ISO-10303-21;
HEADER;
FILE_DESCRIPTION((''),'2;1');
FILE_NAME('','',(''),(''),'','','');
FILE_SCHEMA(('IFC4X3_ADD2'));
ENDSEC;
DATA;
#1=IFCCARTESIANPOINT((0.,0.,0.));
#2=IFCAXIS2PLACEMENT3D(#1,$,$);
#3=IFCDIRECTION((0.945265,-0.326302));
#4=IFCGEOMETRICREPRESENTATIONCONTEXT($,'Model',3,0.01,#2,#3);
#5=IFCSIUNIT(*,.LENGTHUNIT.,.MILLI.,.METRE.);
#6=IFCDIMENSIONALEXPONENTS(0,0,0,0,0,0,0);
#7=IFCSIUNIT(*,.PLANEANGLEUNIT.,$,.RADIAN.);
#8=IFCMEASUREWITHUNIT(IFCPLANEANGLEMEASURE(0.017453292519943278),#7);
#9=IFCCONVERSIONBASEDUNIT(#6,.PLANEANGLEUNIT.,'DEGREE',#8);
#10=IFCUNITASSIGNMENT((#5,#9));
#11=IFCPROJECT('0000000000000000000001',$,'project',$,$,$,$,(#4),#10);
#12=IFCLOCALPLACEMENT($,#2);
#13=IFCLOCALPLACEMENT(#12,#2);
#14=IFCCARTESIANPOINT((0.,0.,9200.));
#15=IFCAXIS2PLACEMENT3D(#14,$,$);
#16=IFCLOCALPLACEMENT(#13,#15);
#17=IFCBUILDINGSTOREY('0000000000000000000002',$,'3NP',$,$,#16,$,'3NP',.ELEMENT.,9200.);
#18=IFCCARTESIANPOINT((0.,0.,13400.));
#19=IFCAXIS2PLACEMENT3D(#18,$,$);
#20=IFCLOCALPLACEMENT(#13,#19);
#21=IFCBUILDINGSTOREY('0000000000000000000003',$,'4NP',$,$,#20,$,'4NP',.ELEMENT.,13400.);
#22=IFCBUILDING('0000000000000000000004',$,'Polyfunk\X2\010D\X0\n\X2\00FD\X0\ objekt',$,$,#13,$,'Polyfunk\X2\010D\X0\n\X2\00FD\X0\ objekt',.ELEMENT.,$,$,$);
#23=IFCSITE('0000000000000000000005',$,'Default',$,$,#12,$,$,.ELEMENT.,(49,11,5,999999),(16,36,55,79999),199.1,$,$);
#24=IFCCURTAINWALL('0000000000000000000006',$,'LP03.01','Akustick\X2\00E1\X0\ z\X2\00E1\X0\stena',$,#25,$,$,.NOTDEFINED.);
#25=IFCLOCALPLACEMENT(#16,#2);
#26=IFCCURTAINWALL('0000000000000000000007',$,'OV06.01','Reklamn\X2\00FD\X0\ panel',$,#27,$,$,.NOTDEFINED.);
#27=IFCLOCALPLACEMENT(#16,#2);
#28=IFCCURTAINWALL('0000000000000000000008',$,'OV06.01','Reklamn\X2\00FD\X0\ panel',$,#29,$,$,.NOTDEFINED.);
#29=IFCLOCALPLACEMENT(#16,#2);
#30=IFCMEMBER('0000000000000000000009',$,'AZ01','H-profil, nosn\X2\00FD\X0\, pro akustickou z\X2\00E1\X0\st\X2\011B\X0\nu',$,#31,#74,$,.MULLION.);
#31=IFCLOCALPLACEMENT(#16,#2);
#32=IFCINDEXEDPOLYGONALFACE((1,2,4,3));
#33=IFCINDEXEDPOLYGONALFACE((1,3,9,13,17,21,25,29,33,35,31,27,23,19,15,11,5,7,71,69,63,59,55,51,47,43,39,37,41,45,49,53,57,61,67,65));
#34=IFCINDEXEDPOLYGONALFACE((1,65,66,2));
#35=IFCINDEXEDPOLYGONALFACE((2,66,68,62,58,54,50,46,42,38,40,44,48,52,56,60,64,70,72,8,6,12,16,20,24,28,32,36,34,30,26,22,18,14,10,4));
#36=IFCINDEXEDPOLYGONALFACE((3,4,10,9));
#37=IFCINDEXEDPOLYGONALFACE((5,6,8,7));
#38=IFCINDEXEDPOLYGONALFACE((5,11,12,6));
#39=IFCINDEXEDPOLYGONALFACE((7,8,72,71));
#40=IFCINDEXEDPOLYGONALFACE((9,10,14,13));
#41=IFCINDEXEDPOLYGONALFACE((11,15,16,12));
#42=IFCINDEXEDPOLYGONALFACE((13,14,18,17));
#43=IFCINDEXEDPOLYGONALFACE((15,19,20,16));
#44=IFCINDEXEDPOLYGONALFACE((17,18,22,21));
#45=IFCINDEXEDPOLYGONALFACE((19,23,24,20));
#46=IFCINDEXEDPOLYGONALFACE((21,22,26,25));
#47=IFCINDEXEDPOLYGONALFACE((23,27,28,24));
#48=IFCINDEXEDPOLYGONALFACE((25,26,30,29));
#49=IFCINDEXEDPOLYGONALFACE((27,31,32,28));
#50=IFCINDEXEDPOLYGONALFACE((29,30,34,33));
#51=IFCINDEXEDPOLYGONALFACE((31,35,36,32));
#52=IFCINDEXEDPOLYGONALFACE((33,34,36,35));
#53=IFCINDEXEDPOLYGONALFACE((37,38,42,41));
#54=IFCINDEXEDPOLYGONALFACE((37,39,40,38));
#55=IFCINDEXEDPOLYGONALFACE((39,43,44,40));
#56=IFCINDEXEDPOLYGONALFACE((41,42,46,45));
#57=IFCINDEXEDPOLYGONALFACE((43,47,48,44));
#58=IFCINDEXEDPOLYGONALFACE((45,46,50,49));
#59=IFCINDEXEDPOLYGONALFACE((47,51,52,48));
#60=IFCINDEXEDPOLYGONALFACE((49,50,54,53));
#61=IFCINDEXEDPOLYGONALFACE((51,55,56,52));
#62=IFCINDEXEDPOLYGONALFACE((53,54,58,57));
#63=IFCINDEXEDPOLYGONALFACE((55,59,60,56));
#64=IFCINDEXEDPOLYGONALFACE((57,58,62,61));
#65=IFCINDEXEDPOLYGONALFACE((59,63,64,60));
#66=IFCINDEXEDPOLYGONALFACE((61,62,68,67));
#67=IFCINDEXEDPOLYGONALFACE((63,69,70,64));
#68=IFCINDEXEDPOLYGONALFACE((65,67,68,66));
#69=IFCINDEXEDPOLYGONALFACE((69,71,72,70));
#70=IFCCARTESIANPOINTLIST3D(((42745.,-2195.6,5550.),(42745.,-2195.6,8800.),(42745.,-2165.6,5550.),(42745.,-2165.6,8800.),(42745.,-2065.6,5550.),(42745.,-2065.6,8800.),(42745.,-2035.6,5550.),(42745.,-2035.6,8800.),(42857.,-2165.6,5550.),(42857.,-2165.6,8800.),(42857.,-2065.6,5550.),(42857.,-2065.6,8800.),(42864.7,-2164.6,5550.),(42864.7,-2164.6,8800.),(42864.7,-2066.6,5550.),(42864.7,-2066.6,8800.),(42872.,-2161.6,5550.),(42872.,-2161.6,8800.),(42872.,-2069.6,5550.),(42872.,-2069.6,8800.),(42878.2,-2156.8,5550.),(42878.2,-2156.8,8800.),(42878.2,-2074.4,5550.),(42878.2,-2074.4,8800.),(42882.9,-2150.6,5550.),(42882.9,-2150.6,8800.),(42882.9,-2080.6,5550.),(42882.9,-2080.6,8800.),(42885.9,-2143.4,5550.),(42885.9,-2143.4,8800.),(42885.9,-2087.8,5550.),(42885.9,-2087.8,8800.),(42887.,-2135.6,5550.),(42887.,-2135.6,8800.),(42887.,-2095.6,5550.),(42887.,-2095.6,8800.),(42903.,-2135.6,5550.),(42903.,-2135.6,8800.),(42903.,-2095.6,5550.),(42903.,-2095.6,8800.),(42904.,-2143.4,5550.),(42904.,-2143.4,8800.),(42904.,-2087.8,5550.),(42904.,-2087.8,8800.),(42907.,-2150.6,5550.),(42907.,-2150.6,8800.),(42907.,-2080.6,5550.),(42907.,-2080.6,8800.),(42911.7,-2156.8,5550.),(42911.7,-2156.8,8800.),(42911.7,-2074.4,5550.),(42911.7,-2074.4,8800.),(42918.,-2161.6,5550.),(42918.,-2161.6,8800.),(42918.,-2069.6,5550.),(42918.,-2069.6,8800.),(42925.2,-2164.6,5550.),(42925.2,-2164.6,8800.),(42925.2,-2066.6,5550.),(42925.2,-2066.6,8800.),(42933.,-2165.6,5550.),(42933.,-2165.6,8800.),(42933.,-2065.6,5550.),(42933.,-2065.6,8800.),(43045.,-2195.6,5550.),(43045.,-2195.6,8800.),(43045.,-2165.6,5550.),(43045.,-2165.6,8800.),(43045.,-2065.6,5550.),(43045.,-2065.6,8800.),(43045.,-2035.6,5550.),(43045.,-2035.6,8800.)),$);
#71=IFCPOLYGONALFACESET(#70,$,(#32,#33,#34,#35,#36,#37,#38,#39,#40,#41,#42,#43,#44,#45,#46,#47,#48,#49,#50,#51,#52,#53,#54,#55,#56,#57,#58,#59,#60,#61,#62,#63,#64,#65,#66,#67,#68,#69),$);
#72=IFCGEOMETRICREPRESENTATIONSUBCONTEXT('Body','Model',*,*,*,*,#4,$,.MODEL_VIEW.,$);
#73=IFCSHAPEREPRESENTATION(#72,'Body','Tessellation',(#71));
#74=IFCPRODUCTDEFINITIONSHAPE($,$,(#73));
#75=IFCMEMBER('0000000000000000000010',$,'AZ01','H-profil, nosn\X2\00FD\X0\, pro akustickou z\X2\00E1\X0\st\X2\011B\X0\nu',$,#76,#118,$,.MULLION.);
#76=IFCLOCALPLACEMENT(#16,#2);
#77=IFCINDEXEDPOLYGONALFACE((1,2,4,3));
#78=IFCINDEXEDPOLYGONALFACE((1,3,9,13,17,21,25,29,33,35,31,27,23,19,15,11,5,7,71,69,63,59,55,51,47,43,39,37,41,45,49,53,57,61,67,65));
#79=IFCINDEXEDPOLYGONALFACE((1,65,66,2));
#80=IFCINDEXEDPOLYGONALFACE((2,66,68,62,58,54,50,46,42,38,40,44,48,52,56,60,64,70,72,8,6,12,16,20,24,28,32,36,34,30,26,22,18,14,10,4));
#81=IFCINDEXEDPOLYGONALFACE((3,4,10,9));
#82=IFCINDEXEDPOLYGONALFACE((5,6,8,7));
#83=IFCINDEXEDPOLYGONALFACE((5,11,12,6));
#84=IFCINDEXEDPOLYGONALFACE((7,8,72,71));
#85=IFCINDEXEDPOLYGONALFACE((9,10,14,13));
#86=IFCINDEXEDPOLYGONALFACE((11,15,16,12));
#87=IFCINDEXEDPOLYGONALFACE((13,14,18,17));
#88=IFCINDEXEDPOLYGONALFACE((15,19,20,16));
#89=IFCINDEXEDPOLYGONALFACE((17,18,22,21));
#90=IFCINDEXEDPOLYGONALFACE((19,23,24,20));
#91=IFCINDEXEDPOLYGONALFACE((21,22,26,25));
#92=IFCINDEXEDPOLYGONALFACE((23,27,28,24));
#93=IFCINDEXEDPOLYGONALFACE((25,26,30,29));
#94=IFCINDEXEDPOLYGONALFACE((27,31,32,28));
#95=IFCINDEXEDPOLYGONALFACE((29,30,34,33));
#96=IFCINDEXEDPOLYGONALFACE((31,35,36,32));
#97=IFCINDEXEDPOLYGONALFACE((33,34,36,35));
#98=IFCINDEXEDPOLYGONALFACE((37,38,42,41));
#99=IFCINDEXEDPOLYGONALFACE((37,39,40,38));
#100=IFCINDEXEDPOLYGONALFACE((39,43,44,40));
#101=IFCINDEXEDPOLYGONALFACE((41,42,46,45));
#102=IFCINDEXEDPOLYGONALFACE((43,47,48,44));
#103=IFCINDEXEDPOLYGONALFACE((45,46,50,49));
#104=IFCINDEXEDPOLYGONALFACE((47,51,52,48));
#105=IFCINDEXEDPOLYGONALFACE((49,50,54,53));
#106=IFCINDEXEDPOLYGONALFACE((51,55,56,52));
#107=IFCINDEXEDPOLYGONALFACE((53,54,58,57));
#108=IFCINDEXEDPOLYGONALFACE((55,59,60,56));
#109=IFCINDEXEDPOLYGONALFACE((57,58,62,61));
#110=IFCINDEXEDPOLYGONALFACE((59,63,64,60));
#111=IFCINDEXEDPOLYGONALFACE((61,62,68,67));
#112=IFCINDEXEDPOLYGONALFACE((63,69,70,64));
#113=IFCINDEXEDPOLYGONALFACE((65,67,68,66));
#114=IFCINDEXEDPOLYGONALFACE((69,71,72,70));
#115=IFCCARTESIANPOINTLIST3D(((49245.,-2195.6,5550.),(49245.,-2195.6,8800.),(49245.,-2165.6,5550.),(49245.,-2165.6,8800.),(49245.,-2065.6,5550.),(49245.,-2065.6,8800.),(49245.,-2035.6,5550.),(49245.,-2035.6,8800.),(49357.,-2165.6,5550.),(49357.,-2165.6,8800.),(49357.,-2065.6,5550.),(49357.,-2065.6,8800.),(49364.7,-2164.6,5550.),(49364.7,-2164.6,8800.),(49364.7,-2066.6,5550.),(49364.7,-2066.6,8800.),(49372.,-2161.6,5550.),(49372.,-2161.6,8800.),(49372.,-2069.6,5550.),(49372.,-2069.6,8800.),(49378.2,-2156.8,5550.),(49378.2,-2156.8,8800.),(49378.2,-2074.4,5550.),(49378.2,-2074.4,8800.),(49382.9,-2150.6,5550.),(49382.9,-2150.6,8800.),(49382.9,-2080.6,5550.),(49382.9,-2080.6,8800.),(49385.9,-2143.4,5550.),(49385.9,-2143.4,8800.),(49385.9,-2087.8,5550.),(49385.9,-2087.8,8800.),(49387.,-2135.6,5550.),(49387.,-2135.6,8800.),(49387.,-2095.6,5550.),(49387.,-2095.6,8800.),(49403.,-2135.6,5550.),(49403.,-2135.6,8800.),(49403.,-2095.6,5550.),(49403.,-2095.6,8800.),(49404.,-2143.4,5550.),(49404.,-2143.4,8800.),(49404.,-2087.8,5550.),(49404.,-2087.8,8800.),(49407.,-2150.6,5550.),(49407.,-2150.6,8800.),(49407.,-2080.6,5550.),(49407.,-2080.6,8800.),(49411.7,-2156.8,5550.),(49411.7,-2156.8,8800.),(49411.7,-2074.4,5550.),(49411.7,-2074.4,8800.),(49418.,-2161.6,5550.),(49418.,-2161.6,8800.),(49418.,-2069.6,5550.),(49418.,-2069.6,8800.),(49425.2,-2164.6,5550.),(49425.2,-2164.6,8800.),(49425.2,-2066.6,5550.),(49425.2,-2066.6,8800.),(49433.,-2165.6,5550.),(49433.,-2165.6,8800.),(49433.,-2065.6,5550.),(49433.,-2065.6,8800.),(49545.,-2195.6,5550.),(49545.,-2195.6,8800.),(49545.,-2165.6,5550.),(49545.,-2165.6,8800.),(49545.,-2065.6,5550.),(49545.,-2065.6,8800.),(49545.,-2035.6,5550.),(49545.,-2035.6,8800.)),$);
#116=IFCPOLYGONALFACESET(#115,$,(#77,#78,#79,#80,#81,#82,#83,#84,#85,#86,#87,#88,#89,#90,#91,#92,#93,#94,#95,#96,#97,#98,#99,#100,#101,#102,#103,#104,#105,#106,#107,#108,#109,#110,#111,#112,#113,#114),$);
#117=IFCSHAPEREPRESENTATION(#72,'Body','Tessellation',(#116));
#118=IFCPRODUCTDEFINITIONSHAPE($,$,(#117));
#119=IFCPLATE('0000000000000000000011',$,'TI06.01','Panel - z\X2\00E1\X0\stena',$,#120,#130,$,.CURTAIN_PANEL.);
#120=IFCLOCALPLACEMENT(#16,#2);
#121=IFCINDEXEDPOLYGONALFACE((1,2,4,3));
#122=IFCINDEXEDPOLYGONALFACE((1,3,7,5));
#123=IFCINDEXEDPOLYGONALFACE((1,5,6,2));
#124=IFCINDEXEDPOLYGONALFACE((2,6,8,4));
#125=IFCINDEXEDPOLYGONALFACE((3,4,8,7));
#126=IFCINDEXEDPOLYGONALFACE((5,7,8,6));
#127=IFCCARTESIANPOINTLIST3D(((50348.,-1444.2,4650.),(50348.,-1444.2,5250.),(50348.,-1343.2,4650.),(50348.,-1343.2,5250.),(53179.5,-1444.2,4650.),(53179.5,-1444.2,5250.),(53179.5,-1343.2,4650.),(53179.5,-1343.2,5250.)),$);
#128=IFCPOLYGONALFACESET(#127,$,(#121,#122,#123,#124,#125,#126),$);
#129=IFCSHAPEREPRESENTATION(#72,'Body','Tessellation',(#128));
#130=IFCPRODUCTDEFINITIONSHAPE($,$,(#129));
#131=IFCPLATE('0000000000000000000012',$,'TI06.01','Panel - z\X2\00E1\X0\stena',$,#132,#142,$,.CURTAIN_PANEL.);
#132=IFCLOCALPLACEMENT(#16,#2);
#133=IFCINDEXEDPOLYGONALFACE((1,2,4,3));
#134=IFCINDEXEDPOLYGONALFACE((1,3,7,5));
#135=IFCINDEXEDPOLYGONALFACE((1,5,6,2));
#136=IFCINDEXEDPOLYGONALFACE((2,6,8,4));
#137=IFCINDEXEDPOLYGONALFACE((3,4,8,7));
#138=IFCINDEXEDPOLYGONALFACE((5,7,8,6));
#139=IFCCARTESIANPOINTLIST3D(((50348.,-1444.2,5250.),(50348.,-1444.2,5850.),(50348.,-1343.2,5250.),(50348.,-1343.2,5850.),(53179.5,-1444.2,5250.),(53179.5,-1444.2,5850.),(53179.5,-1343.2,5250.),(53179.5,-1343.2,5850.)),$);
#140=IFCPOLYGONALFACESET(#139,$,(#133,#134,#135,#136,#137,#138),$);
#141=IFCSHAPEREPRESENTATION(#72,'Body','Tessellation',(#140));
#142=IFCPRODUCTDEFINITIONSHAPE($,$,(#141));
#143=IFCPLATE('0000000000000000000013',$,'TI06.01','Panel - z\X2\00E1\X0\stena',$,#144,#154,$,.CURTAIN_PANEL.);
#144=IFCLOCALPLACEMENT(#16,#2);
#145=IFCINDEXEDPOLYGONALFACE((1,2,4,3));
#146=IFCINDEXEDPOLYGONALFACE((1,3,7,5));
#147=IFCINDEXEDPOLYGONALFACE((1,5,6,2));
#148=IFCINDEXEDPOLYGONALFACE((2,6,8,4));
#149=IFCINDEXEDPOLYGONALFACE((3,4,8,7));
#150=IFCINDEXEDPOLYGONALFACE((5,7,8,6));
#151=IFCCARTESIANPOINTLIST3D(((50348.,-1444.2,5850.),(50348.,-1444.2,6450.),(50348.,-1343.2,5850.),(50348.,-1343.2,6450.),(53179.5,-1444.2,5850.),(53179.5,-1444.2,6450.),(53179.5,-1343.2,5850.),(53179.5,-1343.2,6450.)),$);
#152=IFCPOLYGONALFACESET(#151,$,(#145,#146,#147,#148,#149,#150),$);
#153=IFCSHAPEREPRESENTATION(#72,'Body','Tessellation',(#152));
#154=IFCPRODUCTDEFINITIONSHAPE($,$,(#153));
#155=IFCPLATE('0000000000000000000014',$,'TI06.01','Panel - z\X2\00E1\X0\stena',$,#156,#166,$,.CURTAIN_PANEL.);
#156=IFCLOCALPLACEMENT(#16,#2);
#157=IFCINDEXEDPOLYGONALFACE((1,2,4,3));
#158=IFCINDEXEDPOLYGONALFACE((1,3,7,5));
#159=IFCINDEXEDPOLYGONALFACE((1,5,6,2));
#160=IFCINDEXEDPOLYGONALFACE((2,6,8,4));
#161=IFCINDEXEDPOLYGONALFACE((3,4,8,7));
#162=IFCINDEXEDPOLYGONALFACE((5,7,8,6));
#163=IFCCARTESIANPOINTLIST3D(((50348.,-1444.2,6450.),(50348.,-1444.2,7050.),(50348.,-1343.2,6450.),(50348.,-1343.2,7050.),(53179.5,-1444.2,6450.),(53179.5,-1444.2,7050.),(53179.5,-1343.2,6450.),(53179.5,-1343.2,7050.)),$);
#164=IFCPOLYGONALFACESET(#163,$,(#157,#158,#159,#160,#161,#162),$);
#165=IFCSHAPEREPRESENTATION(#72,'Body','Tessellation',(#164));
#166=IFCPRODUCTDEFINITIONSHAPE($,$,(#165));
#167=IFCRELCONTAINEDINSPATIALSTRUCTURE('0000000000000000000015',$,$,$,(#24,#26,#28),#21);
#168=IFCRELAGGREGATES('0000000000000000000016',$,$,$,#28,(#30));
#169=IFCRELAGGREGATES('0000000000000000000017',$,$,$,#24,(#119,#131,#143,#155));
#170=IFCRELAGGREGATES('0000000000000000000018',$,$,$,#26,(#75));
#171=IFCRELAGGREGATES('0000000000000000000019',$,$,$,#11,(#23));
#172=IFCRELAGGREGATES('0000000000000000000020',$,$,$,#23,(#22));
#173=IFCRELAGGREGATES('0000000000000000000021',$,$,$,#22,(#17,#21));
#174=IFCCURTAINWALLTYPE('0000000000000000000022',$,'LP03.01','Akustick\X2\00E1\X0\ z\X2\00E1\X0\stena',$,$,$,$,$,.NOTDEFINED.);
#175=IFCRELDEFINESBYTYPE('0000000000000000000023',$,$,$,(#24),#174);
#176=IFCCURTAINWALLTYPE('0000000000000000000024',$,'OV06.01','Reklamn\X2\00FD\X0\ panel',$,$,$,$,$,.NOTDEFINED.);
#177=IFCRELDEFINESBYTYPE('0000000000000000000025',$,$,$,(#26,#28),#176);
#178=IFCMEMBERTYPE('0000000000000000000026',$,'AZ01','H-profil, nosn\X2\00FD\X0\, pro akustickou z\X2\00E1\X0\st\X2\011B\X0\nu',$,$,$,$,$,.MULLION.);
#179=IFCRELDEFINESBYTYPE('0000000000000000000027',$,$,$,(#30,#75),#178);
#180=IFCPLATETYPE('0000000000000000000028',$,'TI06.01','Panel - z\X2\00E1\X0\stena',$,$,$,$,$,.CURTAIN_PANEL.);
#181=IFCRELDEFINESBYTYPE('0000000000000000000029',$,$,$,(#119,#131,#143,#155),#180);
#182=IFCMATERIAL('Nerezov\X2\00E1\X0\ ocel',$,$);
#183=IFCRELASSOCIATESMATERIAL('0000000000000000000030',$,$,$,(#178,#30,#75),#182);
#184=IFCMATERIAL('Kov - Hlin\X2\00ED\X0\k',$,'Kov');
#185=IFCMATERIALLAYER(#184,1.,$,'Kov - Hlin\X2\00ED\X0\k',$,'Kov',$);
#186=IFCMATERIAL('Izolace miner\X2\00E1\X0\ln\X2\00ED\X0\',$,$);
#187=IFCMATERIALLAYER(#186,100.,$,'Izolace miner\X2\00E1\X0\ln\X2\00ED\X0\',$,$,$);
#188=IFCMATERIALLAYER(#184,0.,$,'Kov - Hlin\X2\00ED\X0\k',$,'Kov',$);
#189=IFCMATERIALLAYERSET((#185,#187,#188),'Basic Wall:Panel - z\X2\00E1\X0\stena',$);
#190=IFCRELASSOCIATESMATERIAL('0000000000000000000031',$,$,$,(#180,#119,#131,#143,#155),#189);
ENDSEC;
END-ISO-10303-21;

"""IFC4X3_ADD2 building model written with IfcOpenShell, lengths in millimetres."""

from ifc_helpers import new_model, entity, si_unit, converted_unit, direction, frame, frame_2d, origin, place, context, subcontext, project, spatial, polyline, circle_curve, parameter, trimmed, segment, composite_curve, rectangle, outline, extrude, source, transform, mapped, material, layer, layer_set, layer_usage, material_profile, profile_set, profile_usage, type_object, element, aggregate, save


model = new_model("IFC4X3_ADD2")

# Units and contexts
model_context = context("Model", 3, precision=0.01, world=origin(), true_north=direction((0.945265, -0.326302)))
body_context = subcontext(model_context, "Body", "Model", "MODEL_VIEW")
ifc_project = project(units=[si_unit("LENGTHUNIT", "METRE", prefix="MILLI"), converted_unit("PLANEANGLEUNIT", "DEGREE", entity("IfcPlaneAngleMeasure", 0.017453292519943278), si_unit("PLANEANGLEUNIT", "RADIAN"), dimensions=[0, 0, 0, 0, 0, 0, 0])], contexts=[model_context])

# Site, building, storey
site_placement = place(None, origin())
site = spatial("IfcSite", under=ifc_project, at=site_placement, Name="Default", CompositionType="ELEMENT", RefLatitude=(49, 11, 5, 999999), RefLongitude=(16, 36, 55, 79999), RefElevation=199.1)
building_placement = place(site_placement, origin())
building = spatial("IfcBuilding", under=site, at=building_placement, Name="Polyfunkčný objekt", LongName="Polyfunkčný objekt", CompositionType="ELEMENT")
storey_1_placement = place(building_placement, frame((0.0, 0.0, 9200.0)))
storey_1 = spatial("IfcBuildingStorey", under=building, at=storey_1_placement, Name="3NP", LongName="3NP", CompositionType="ELEMENT", Elevation=9200.0)

# Shared definitions
storey_2_placement = place(building_placement, frame((0.0, 0.0, 13400.0)))
storey_2 = spatial("IfcBuildingStorey", under=building, at=storey_2_placement, Name="4NP", LongName="4NP", CompositionType="ELEMENT", Elevation=13400.0)

# Curtain wall
curtain_wall_type_1 = type_object("IfcCurtainWallType", Name="LP03.01", Description="Akustická zástena", PredefinedType="NOTDEFINED")
curtain_wall_1_placement = place(storey_2_placement, frame((0.0, 0.0, -13400.0)))
curtain_wall_1 = element("IfcCurtainWall", 1, at=curtain_wall_1_placement, inside=storey_2, type_object=curtain_wall_type_1, Name="LP03.01", Description="Akustická zástena", PredefinedType="NOTDEFINED")
ifc_material_1 = material(Name="Nerezová ocel")
ifc_material_profile_1 = material_profile(ifc_material_1, outline(composite_curve([segment(polyline([(50.0, -150.0), (80.0, -150.0)]), True, "CONTINUOUS"), segment(polyline([(80.0, -150.0), (80.0, 150.0)]), True, "CONTINUOUS"), segment(polyline([(80.0, 150.0), (50.0, 150.0)]), True, "CONTINUOUS"), segment(polyline([(50.0, 150.0), (50.0, 38.0)]), True, "CONTINUOUS"), segment(trimmed(circle_curve(frame_2d((20.0, 38.0), x_axis=(0.0, 1.0)), 30.0), [parameter(180.0)], [parameter(270.0)], True, "PARAMETER"), False, "CONTINUOUS"), segment(polyline([(20.0, 8.0), (-20.0, 8.0)]), True, "CONTINUOUS"), segment(trimmed(circle_curve(frame_2d((-20.0, 38.0), x_axis=(0.0, 1.0)), 30.0), [parameter(90.0)], [parameter(180.0)], True, "PARAMETER"), False, "CONTINUOUS"), segment(polyline([(-50.0, 38.0), (-50.0, 150.0)]), True, "CONTINUOUS"), segment(polyline([(-50.0, 150.0), (-80.0, 150.0)]), True, "CONTINUOUS"), segment(polyline([(-80.0, 150.0), (-80.0, -150.0)]), True, "CONTINUOUS"), segment(polyline([(-80.0, -150.0), (-50.0, -150.0)]), True, "CONTINUOUS"), segment(polyline([(-50.0, -150.0), (-50.0, -38.0)]), True, "CONTINUOUS"), segment(trimmed(circle_curve(frame_2d((-20.0, -38.0), x_axis=(0.0, 1.0)), 30.0), [parameter(0.0)], [parameter(90.0)], True, "PARAMETER"), False, "CONTINUOUS"), segment(polyline([(-20.0, -8.0), (20.0, -8.0)]), True, "CONTINUOUS"), segment(trimmed(circle_curve(frame_2d((20.0, -38.0), x_axis=(0.0, 1.0)), 30.0), [parameter(270.0)], [parameter(0.0)], True, "PARAMETER"), False, "CONTINUOUS"), segment(polyline([(50.0, -38.0), (50.0, -150.0)]), True, "CONTINUOUS")], self_intersect=False)), Name="Profil zástena")
ifc_profile_set_1 = profile_set([ifc_material_profile_1], Name="Profil zástena")
ifc_profile_usage_1 = profile_usage(ifc_profile_set_1)
member_type_1 = type_object("IfcMemberType", Name="AZ01", Description="H-profil, nosný, pro akustickou zástěnu", PredefinedType="MULLION", material=ifc_profile_set_1)

# Curtain walls
curtain_wall_type_2 = type_object("IfcCurtainWallType", Name="OV06.01", Description="Reklamný panel", PredefinedType="NOTDEFINED")
curtain_wall_2_placement = place(storey_2_placement, frame((0.0, 0.0, -13400.0)))
curtain_wall_2 = element("IfcCurtainWall", 2, at=curtain_wall_2_placement, inside=storey_2, type_object=curtain_wall_type_2, Name="OV06.01", Description="Reklamný panel", PredefinedType="NOTDEFINED")
curtain_wall_3_placement = place(storey_2_placement, frame((0.0, 0.0, -13400.0)))
curtain_wall_3 = element("IfcCurtainWall", 3, at=curtain_wall_3_placement, inside=storey_2, type_object=curtain_wall_type_2, Name="OV06.01", Description="Reklamný panel", PredefinedType="NOTDEFINED")

# Members
shared_shape_1 = source(origin(), body_context, "Body", "SweptSolid", [
    extrude(outline(composite_curve([segment(polyline([(-150.0, -50.0), (-150.0, -80.0)]), True, "CONTINUOUS"), segment(polyline([(-150.0, -80.0), (150.0, -80.0)]), True, "CONTINUOUS"), segment(polyline([(150.0, -80.0), (150.0, -50.0)]), True, "CONTINUOUS"), segment(polyline([(150.0, -50.0), (38.0, -50.0)]), True, "CONTINUOUS"), segment(trimmed(circle_curve(frame_2d((38.0, -20.0), x_axis=(1.0, 0.0)), 30.0), [parameter(180.0)], [parameter(270.0)], True, "PARAMETER"), False, "CONTINUOUS"), segment(polyline([(8.0, -20.0), (8.0, 20.0)]), True, "CONTINUOUS"), segment(trimmed(circle_curve(frame_2d((38.0, 20.0), x_axis=(1.0, 0.0)), 30.0), [parameter(90.0)], [parameter(180.0)], True, "PARAMETER"), False, "CONTINUOUS"), segment(polyline([(38.0, 50.0), (150.0, 50.0)]), True, "CONTINUOUS"), segment(polyline([(150.0, 50.0), (150.0, 80.0)]), True, "CONTINUOUS"), segment(polyline([(150.0, 80.0), (-150.0, 80.0)]), True, "CONTINUOUS"), segment(polyline([(-150.0, 80.0), (-150.0, 50.0)]), True, "CONTINUOUS"), segment(polyline([(-150.0, 50.0), (-38.0, 50.0)]), True, "CONTINUOUS"), segment(trimmed(circle_curve(frame_2d((-38.0, 20.0), x_axis=(1.0, 0.0)), 30.0), [parameter(0.0)], [parameter(90.0)], True, "PARAMETER"), False, "CONTINUOUS"), segment(polyline([(-8.0, 20.0), (-8.0, -20.0)]), True, "CONTINUOUS"), segment(trimmed(circle_curve(frame_2d((-38.0, -20.0), x_axis=(1.0, 0.0)), 30.0), [parameter(270.0)], [parameter(0.0)], True, "PARAMETER"), False, "CONTINUOUS"), segment(polyline([(-38.0, -50.0), (-150.0, -50.0)]), True, "CONTINUOUS")], self_intersect=False)), frame((-150.0, 0.0, -3250.0), z_axis=(0.0, 0.0, -1.0), x_axis=(1.0, 0.0, 0.0)), (0.0, 0.0, -1.0), 3250.0),
])
member_1_placement = place(curtain_wall_3_placement, frame((43045.0, -2115.6, 14750.0), z_axis=(0.0, 0.0, -1.0), x_axis=(1.0, 0.0, 0.0)))
member_1 = element("IfcMember", 4, at=member_1_placement, type_object=member_type_1, material=ifc_profile_usage_1, Name="AZ01", Description="H-profil, nosný, pro akustickou zástěnu", PredefinedType="MULLION", context=body_context, shape_type="MappedRepresentation", body=[
    mapped(shared_shape_1, transform((0.0, 0.0, 0.0), scale=1.0)),
])
aggregate(curtain_wall_3, [member_1])
member_2_placement = place(curtain_wall_2_placement, frame((49545.0, -2115.6, 14750.0), z_axis=(0.0, 0.0, -1.0), x_axis=(1.0, 0.0, 0.0)))
member_2 = element("IfcMember", 5, at=member_2_placement, type_object=member_type_1, material=ifc_profile_usage_1, Name="AZ01", Description="H-profil, nosný, pro akustickou zástěnu", PredefinedType="MULLION", context=body_context, shape_type="MappedRepresentation", body=[
    mapped(shared_shape_1, transform((0.0, 0.0, 0.0), scale=1.0)),
])

# Plates
ifc_material_2 = material(Name="Kov - Hliník", Category="Kov")
ifc_layer_1 = layer(ifc_material_2, 1.0, Name="Kov - Hliník", Category="Kov")
ifc_material_3 = material(Name="Izolace minerální")
ifc_layer_2 = layer(ifc_material_3, 100.0, Name="Izolace minerální")
ifc_layer_3 = layer(ifc_material_2, 0.0, Name="Kov - Hliník", Category="Kov")
ifc_layer_set_1 = layer_set([ifc_layer_1, ifc_layer_2, ifc_layer_3], Name="Basic Wall:Panel - zástena")
ifc_layer_usage_1 = layer_usage(ifc_layer_set_1, "AXIS2", "POSITIVE", -50.5)
plate_type = type_object("IfcPlateType", Name="TI06.01", Description="Panel - zástena", PredefinedType="CURTAIN_PANEL", material=ifc_layer_set_1)
plate_1_placement = place(storey_2_placement, frame((50348.0, -1393.7, 450.0)))
plate_1 = element("IfcPlate", 6, at=plate_1_placement, type_object=plate_type, material=ifc_layer_usage_1, Name="TI06.01", Description="Panel - zástena", PredefinedType="CURTAIN_PANEL", context=body_context, shape_type="SweptSolid", body=[
    extrude(rectangle(XDim=101.0, YDim=2831.5, at=frame_2d((0.0, 0.0), x_axis=(1.0, 0.0))), frame((1415.8, 0.0, 0.0), z_axis=(0.0, 0.0, 1.0), x_axis=(0.0, 1.0, 0.0)), (0.0, 0.0, 1.0), 600.0),
])
ifc_layer_usage_2 = layer_usage(ifc_layer_set_1, "AXIS2", "POSITIVE", -50.5)
plate_2_placement = place(storey_2_placement, frame((50348.0, -1393.7, 1050.0)))
plate_2 = element("IfcPlate", 7, at=plate_2_placement, type_object=plate_type, material=ifc_layer_usage_2, Name="TI06.01", Description="Panel - zástena", PredefinedType="CURTAIN_PANEL", context=body_context, shape_type="SweptSolid", body=[
    extrude(rectangle(XDim=101.0, YDim=2831.5, at=frame_2d((0.0, 0.0), x_axis=(1.0, 0.0))), frame((1415.8, 0.0, 0.0), z_axis=(0.0, 0.0, 1.0), x_axis=(0.0, 1.0, 0.0)), (0.0, 0.0, 1.0), 600.0),
])
ifc_layer_usage_3 = layer_usage(ifc_layer_set_1, "AXIS2", "POSITIVE", -50.5)
plate_3_placement = place(storey_2_placement, frame((50348.0, -1393.7, 1650.0)))
plate_3 = element("IfcPlate", 8, at=plate_3_placement, type_object=plate_type, material=ifc_layer_usage_3, Name="TI06.01", Description="Panel - zástena", PredefinedType="CURTAIN_PANEL", context=body_context, shape_type="SweptSolid", body=[
    extrude(rectangle(XDim=101.0, YDim=2831.5, at=frame_2d((0.0, 0.0), x_axis=(1.0, 0.0))), frame((1415.8, 0.0, 0.0), z_axis=(0.0, 0.0, 1.0), x_axis=(0.0, 1.0, 0.0)), (0.0, 0.0, 1.0), 600.0),
])
ifc_layer_usage_4 = layer_usage(ifc_layer_set_1, "AXIS2", "POSITIVE", -50.5)
plate_4_placement = place(storey_2_placement, frame((50348.0, -1393.7, 2250.0)))
plate_4 = element("IfcPlate", 9, at=plate_4_placement, type_object=plate_type, material=ifc_layer_usage_4, Name="TI06.01", Description="Panel - zástena", PredefinedType="CURTAIN_PANEL", context=body_context, shape_type="SweptSolid", body=[
    extrude(rectangle(XDim=101.0, YDim=2831.5, at=frame_2d((0.0, 0.0), x_axis=(1.0, 0.0))), frame((1415.8, 0.0, 0.0), z_axis=(0.0, 0.0, 1.0), x_axis=(0.0, 1.0, 0.0)), (0.0, 0.0, 1.0), 600.0),
])
aggregate(curtain_wall_1, [plate_1, plate_2, plate_3, plate_4])
aggregate(curtain_wall_2, [member_2])

save(model, "model.ifc")
